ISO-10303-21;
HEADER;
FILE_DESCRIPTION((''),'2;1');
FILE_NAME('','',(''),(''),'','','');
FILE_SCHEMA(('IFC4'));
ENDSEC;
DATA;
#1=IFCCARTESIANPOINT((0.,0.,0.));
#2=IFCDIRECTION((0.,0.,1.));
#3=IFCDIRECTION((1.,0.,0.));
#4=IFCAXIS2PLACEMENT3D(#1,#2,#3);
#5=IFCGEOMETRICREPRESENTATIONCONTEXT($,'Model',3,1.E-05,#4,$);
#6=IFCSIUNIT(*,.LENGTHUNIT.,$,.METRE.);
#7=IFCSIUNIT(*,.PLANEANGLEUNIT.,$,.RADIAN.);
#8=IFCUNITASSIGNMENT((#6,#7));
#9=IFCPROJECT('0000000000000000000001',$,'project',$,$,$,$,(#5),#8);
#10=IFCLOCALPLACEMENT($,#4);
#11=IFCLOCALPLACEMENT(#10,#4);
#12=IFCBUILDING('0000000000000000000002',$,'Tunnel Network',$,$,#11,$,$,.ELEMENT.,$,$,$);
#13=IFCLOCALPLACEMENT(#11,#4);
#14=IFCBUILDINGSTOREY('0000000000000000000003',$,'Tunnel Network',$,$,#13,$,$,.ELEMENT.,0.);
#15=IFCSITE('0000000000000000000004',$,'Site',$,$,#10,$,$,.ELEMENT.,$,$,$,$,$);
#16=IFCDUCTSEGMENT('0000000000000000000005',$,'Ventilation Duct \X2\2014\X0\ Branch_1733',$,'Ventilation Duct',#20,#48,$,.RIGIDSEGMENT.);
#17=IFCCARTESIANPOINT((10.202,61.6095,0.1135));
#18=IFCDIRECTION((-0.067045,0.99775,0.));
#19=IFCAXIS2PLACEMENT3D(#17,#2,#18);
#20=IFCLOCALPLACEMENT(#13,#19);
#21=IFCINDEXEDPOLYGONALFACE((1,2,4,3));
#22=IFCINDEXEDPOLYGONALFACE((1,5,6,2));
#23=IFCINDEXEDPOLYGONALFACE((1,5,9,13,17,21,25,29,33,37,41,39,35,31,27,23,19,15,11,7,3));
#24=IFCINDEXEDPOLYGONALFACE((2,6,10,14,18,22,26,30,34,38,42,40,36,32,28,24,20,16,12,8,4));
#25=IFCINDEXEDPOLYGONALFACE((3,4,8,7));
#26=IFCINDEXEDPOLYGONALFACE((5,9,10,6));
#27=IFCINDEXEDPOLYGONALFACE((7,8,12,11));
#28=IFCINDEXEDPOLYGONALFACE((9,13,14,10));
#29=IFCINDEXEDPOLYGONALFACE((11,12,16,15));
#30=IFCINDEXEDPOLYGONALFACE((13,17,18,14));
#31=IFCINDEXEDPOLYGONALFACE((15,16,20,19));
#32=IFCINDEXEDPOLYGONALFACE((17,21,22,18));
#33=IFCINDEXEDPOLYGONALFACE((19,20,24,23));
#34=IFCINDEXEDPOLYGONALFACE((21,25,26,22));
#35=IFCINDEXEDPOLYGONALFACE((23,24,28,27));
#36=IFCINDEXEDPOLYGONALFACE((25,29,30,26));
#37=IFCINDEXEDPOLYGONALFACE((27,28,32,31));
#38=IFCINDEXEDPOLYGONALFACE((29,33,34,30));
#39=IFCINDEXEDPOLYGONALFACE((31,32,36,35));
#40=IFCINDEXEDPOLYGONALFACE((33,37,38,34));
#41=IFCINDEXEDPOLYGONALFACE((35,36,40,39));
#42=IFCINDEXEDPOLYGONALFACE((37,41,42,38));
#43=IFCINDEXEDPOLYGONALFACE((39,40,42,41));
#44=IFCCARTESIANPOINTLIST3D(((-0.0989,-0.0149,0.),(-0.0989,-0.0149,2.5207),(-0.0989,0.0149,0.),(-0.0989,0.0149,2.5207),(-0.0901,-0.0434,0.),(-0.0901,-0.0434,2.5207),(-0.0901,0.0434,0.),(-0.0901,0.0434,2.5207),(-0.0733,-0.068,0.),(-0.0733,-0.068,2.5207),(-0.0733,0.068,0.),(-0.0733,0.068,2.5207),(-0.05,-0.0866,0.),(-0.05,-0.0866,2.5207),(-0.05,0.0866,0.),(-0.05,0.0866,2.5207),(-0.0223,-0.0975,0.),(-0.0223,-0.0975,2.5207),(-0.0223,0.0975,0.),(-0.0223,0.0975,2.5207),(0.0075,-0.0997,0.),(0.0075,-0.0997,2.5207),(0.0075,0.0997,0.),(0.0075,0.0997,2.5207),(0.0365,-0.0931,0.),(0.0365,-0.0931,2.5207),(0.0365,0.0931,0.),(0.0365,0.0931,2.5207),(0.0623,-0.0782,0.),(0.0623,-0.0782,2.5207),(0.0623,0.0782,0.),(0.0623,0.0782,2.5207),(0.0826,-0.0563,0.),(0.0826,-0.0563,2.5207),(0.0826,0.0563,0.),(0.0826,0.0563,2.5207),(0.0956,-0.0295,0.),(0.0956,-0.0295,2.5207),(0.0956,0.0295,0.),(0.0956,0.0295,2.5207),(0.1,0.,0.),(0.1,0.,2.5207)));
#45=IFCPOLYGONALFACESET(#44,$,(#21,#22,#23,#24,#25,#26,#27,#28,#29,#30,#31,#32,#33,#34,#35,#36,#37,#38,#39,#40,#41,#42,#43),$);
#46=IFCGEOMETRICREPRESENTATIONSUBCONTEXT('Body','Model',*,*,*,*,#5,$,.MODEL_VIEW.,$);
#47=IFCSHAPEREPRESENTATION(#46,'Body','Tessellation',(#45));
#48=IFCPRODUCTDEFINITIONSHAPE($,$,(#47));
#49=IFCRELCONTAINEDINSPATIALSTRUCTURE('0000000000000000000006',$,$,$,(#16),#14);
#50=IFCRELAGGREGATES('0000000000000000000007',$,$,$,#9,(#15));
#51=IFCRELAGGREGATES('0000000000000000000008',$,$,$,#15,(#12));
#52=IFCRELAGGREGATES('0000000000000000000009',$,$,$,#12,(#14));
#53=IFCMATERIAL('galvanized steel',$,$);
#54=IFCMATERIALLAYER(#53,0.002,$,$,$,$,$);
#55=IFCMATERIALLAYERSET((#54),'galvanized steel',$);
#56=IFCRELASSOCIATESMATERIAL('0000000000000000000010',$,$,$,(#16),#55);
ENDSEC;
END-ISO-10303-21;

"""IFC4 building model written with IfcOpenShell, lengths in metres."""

from ifc_helpers import new_model, entity, si_unit, frame, origin_with_axes, place, context, subcontext, project, spatial, material, layer, layer_set, layer_usage, element, save


model = new_model("IFC4")

# Units and contexts
model_context = context("Model", 3, precision=1e-05, world=origin_with_axes())
body_context = subcontext(model_context, "Body", "Model", "MODEL_VIEW")
ifc_project = project(units=[si_unit("LENGTHUNIT", "METRE"), si_unit("PLANEANGLEUNIT", "RADIAN")], contexts=[model_context])

# Site, building, storey
site_placement = place(None, origin_with_axes())
site = spatial("IfcSite", under=ifc_project, at=site_placement, Name="Site", CompositionType="ELEMENT")
building_placement = place(site_placement, origin_with_axes())
building = spatial("IfcBuilding", under=site, at=building_placement, Name="Tunnel Network", CompositionType="ELEMENT")
storey_placement = place(building_placement, origin_with_axes())
storey = spatial("IfcBuildingStorey", under=building, at=storey_placement, Name="Tunnel Network", CompositionType="ELEMENT", Elevation=0.0)

# Shared definitions
ifc_material_1 = material(Name="galvanized steel")
ifc_layer_1 = layer(ifc_material_1, 0.002)
ifc_layer_set_1 = layer_set([ifc_layer_1], Name="galvanized steel")

# Duct segment
ifc_layer_usage_1 = layer_usage(ifc_layer_set_1, "AXIS2", "POSITIVE", 0.0)
duct_segment_1_placement = place(storey_placement, frame((10.202, 61.6095, 0.1135), z_axis=(0.0, 0.0, 1.0), x_axis=(-0.067045, 0.99775, 0.0)))
element("IfcDuctSegment", 1, at=duct_segment_1_placement, inside=storey, material=ifc_layer_usage_1, Name="Ventilation Duct — Branch_1733", ObjectType="Ventilation Duct", PredefinedType="RIGIDSEGMENT", context=body_context, shape_type="AdvancedSweptSolid", body=[
    entity("IfcSweptDiskSolid", entity("IfcPolyline", [entity("IfcCartesianPoint", [0.0, 0.0, 0.0]), entity("IfcCartesianPoint", [0.0, 0.0, 2.5207])]), 0.1),
])

save(model, "model.ifc")
